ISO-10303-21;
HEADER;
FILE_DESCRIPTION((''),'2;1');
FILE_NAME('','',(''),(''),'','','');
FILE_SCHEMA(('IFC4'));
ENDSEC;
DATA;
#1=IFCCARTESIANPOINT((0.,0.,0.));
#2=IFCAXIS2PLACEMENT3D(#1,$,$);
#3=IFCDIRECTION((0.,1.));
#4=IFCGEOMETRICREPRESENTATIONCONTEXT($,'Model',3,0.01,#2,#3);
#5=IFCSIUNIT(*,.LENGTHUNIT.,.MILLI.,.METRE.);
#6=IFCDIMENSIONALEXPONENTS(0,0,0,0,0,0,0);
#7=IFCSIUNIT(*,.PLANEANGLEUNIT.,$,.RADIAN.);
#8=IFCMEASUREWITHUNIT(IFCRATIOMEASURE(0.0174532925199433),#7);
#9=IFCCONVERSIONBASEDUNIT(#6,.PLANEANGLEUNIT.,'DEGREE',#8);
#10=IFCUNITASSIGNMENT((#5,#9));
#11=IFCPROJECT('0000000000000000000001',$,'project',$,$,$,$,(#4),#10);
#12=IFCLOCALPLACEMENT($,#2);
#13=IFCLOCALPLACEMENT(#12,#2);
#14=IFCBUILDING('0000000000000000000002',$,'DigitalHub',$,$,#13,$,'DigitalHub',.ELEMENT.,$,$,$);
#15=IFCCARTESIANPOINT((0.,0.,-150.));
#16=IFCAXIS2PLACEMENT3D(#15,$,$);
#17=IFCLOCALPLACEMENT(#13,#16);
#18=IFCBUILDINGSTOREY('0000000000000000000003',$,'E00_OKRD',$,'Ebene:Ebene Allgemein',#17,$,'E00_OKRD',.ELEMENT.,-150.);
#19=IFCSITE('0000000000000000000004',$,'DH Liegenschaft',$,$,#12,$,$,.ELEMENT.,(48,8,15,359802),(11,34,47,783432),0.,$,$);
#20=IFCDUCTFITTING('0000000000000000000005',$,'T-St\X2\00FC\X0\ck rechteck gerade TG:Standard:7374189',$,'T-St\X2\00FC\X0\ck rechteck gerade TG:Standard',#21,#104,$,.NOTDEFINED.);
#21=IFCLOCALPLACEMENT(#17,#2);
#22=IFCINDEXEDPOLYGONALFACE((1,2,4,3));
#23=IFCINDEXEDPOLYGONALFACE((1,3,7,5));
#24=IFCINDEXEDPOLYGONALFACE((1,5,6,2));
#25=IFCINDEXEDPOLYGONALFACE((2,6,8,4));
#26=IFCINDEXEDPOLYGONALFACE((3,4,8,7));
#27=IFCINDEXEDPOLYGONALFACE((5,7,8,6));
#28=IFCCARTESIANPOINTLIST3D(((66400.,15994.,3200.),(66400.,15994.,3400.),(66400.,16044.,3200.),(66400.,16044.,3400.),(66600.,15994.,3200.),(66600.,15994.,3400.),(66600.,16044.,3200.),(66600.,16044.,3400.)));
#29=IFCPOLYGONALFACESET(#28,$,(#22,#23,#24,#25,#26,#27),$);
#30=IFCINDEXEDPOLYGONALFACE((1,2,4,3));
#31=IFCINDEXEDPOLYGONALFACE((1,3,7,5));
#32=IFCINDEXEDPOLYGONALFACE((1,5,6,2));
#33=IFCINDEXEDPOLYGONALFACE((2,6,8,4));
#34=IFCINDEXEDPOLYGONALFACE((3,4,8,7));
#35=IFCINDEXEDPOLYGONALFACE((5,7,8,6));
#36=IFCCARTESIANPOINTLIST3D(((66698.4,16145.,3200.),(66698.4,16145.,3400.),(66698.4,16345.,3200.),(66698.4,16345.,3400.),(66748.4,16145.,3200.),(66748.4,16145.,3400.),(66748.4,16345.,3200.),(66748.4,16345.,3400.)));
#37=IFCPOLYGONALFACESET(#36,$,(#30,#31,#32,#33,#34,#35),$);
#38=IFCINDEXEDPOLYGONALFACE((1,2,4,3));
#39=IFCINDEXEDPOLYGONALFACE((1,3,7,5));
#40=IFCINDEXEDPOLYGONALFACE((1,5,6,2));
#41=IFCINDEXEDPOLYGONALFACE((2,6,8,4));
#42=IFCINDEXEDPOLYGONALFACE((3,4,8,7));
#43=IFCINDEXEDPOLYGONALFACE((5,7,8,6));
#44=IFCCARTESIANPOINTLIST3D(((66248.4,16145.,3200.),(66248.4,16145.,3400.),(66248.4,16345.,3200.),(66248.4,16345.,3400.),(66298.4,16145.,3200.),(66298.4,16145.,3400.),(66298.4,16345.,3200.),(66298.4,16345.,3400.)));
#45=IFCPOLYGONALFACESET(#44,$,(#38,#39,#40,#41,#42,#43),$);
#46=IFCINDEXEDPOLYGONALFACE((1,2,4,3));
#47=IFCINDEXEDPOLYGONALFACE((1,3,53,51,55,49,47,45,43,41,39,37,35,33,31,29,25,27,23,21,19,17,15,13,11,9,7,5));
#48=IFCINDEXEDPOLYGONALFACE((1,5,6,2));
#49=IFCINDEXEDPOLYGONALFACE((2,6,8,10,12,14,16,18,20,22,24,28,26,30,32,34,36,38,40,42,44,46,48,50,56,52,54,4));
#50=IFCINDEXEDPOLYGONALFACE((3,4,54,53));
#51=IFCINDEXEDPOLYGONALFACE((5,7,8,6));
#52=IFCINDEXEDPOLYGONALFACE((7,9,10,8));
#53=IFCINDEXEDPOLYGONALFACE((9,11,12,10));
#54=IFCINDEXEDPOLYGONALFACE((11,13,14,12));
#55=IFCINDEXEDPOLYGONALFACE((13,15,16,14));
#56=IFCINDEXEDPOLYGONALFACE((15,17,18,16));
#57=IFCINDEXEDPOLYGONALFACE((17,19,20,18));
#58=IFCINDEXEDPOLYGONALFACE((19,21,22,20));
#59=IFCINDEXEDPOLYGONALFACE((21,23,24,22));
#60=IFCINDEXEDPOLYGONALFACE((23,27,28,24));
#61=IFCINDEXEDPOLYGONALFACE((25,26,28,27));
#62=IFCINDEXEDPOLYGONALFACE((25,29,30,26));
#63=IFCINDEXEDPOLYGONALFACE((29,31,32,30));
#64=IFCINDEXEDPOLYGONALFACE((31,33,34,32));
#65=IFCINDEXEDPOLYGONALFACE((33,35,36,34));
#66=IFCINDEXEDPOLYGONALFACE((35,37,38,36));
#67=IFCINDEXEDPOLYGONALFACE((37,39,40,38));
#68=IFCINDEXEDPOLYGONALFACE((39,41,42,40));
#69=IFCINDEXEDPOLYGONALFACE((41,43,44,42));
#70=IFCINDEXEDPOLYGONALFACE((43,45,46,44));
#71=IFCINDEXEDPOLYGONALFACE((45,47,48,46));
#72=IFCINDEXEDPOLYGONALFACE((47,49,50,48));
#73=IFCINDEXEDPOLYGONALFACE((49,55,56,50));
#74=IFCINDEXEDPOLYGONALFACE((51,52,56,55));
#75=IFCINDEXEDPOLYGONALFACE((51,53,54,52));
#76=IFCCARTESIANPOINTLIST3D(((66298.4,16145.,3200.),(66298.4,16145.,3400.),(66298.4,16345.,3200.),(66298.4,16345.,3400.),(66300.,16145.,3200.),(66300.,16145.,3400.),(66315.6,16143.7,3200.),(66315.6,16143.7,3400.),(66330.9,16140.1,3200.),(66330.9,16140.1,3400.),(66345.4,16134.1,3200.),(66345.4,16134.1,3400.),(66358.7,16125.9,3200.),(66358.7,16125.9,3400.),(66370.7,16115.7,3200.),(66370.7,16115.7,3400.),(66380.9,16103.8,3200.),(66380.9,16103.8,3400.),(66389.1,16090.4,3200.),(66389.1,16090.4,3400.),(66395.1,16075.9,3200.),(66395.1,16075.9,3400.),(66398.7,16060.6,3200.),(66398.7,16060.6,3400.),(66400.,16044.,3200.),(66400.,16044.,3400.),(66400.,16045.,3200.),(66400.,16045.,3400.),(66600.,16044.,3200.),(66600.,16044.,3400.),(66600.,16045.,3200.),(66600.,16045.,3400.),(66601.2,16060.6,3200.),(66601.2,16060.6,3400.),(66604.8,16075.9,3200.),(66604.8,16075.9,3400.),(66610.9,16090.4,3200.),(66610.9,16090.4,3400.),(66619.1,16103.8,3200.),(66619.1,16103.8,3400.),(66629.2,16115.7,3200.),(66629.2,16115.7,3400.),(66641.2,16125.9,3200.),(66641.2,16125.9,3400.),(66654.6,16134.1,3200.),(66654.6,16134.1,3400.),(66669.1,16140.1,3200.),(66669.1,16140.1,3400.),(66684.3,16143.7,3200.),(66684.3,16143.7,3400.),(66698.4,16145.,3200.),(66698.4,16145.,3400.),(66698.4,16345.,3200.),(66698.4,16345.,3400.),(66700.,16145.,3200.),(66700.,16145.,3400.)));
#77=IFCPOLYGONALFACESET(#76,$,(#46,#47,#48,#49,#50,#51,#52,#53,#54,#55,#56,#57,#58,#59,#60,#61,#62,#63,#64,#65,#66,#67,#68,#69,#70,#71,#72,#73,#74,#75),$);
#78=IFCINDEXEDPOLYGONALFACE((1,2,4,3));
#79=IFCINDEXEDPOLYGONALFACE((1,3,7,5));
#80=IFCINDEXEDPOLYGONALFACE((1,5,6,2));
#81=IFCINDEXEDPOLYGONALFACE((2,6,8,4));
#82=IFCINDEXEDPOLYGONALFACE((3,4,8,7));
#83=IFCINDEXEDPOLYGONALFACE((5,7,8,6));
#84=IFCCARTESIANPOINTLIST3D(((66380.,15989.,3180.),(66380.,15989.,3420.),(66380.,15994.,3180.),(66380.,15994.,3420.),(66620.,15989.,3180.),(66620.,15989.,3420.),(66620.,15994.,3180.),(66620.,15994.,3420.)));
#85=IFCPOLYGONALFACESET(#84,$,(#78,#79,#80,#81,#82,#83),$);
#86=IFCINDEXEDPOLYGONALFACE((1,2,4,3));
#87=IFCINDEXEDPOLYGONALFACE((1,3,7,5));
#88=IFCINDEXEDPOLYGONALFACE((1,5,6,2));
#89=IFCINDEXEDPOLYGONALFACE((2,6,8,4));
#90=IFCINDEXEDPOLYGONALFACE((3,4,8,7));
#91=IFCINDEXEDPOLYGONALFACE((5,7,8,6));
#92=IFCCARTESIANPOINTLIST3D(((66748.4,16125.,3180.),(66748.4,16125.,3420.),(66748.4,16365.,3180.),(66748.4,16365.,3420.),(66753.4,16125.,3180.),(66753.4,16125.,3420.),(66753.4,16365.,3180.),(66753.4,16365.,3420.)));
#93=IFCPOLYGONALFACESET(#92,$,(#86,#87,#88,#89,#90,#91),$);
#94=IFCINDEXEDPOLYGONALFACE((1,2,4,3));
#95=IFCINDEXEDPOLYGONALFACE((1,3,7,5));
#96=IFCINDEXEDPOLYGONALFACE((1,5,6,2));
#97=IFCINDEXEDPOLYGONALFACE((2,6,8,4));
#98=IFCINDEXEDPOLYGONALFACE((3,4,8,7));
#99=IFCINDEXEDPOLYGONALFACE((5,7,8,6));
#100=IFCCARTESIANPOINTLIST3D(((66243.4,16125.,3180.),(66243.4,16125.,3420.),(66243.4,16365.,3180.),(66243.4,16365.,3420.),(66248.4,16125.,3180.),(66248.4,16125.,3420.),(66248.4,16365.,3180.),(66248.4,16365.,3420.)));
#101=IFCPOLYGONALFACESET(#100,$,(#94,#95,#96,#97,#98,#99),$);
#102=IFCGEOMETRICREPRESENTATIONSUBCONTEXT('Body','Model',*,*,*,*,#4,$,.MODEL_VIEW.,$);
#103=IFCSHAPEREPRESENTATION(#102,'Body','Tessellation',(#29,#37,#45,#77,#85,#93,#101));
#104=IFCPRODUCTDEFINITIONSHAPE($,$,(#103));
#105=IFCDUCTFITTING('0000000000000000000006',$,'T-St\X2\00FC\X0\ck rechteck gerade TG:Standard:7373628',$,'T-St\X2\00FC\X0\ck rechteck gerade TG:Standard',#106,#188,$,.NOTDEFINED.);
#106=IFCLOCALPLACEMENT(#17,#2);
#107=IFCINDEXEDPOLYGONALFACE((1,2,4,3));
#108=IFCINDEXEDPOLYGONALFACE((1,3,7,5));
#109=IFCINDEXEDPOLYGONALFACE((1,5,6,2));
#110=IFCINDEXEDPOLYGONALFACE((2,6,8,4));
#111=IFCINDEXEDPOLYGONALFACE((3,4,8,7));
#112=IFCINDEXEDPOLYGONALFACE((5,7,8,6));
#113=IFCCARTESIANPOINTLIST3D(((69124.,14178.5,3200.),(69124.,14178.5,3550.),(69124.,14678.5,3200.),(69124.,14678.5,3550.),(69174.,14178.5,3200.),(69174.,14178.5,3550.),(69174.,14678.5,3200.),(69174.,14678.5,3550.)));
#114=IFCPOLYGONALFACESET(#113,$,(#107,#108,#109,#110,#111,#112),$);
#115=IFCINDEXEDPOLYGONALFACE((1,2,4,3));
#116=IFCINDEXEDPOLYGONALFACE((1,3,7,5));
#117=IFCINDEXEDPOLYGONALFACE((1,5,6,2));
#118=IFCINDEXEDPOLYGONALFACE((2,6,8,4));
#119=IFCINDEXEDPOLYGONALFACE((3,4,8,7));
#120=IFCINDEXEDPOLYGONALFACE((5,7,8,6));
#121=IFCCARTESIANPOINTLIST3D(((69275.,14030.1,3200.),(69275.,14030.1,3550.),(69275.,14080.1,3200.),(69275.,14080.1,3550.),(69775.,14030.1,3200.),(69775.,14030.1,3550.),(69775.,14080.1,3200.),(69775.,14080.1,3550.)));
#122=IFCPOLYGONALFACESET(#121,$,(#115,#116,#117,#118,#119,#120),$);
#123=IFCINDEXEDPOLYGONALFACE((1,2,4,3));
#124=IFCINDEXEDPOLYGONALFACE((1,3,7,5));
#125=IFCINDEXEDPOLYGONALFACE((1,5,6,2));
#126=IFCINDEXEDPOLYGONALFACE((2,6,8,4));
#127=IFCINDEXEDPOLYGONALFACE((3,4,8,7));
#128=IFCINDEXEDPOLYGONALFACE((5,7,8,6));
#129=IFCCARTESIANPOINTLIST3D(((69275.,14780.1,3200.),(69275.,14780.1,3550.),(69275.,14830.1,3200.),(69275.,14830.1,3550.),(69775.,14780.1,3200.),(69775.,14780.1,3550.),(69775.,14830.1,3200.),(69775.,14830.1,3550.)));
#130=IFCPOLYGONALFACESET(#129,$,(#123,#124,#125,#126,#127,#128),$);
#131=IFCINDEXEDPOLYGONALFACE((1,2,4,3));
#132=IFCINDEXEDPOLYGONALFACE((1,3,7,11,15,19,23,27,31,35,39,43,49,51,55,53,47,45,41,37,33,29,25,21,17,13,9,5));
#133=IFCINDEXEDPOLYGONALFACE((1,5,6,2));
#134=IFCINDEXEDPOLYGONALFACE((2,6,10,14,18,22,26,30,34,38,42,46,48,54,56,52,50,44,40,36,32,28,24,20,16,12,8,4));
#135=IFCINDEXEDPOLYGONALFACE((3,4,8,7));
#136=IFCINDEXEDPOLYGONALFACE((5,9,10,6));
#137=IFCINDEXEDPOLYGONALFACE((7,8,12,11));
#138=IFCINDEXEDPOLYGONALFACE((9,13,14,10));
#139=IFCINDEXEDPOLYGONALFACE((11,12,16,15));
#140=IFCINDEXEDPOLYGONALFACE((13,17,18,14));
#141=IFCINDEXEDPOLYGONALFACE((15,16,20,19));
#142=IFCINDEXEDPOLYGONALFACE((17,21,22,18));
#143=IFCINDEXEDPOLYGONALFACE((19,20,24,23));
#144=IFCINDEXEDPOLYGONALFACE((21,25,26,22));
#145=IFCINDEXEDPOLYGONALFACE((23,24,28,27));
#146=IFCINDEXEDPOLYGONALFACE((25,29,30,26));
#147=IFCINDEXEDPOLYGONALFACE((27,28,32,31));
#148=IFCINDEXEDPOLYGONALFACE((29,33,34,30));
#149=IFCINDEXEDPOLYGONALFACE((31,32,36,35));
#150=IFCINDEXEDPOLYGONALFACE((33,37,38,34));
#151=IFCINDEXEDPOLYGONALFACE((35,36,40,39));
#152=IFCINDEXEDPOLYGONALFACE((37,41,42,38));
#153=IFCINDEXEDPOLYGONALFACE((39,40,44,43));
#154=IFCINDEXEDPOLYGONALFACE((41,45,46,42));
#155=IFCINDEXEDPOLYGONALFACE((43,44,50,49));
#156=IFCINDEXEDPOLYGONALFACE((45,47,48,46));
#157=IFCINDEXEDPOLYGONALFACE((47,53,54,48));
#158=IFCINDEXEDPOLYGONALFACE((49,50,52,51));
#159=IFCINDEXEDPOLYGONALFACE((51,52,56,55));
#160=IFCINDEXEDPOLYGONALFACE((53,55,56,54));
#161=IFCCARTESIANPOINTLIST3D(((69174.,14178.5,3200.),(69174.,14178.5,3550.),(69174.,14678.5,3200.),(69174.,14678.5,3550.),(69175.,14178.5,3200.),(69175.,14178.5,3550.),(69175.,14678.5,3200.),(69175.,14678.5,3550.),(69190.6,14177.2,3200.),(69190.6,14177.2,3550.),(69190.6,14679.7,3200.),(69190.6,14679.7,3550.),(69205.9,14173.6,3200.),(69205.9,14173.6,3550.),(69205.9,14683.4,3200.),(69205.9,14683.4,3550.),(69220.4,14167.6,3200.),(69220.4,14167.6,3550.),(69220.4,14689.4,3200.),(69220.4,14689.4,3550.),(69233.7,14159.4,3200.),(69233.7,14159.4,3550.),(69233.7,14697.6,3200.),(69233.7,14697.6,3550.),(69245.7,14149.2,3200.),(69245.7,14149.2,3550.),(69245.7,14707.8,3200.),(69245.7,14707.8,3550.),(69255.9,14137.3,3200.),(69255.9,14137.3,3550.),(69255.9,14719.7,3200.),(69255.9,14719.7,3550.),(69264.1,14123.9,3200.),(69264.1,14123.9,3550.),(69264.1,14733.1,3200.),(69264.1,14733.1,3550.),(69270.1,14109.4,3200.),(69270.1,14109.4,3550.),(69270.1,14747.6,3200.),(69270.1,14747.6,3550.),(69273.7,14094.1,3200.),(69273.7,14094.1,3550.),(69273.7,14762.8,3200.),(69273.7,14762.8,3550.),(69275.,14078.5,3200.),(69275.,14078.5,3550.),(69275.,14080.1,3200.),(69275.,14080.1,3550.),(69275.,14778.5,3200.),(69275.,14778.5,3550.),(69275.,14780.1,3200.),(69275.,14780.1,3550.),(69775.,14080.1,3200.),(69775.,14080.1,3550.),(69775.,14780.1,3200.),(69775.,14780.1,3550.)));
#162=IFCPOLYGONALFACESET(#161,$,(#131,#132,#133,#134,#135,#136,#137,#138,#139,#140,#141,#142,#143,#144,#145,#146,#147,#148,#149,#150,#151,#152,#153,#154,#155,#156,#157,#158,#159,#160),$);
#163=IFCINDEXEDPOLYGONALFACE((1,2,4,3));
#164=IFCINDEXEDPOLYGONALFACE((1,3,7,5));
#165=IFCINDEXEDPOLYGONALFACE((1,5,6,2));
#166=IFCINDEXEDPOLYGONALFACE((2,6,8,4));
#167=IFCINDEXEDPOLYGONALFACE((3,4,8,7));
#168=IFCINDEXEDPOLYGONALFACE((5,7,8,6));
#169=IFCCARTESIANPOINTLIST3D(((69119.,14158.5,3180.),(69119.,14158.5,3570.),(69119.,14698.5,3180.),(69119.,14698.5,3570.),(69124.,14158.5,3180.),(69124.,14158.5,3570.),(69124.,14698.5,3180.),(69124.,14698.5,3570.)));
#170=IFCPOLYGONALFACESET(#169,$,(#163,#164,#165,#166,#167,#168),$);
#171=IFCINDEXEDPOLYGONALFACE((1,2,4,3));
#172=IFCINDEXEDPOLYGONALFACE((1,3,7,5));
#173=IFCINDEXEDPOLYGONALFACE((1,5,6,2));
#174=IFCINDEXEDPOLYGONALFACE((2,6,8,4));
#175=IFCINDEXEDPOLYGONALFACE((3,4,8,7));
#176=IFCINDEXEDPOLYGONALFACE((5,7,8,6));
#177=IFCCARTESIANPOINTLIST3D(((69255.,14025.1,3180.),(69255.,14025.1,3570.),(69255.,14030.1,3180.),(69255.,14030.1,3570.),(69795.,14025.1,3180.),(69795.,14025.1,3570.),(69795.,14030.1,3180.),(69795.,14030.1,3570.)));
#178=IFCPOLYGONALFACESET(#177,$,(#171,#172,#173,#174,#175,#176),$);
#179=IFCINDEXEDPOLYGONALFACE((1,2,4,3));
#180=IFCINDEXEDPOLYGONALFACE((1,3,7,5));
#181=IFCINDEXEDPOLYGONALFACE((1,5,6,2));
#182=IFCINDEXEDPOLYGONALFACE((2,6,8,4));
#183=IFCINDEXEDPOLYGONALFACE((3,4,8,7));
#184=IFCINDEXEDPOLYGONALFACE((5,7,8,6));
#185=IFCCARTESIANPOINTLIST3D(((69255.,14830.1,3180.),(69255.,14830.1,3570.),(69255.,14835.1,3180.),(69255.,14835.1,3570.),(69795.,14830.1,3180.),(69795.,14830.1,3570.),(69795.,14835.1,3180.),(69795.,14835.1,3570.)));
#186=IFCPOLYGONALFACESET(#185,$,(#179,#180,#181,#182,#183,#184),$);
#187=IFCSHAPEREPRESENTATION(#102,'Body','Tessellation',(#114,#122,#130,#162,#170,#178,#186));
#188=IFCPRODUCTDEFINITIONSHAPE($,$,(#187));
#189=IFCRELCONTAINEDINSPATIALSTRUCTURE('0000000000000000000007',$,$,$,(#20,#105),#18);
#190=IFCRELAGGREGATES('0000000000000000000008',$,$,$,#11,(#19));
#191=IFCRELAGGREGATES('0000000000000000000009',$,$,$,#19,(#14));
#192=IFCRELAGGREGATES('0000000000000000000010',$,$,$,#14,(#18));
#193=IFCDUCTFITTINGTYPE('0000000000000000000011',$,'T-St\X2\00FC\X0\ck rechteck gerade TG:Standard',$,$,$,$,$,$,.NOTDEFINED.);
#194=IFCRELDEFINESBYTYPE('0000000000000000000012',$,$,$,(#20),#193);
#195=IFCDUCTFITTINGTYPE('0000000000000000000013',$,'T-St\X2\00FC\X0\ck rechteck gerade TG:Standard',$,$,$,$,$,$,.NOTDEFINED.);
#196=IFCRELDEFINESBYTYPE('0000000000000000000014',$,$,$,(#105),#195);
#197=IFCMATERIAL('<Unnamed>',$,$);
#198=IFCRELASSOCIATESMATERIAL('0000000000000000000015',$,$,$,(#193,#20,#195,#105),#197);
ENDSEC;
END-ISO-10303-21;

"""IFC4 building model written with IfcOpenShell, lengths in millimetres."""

from ifc_helpers import new_model, entity, si_unit, converted_unit, direction, frame, origin, place, context, subcontext, project, spatial, indexed_curve, outline, extrude, source, transform, mapped, material, type_object, type_shapes, element, save


model = new_model("IFC4")

# Units and contexts
model_context = context("Model", 3, precision=0.01, world=origin(), true_north=direction((0.0, 1.0)))
body_context = subcontext(model_context, "Body", "Model", "MODEL_VIEW")
ifc_project = project(units=[si_unit("LENGTHUNIT", "METRE", prefix="MILLI"), converted_unit("PLANEANGLEUNIT", "DEGREE", entity("IfcRatioMeasure", 0.0174532925199433), si_unit("PLANEANGLEUNIT", "RADIAN"), dimensions=[0, 0, 0, 0, 0, 0, 0])], contexts=[model_context])

# Site, building, storey
site_placement = place(None, origin())
site = spatial("IfcSite", under=ifc_project, at=site_placement, Name="DH Liegenschaft", CompositionType="ELEMENT", RefLatitude=(48, 8, 15, 359802), RefLongitude=(11, 34, 47, 783432), RefElevation=0.0)
building_placement = place(site_placement, origin())
building = spatial("IfcBuilding", under=site, at=building_placement, Name="DigitalHub", LongName="DigitalHub", CompositionType="ELEMENT")
storey_placement = place(building_placement, frame((0.0, 0.0, -150.0)))
storey = spatial("IfcBuildingStorey", under=building, at=storey_placement, Name="E00_OKRD", ObjectType="Ebene:Ebene Allgemein", LongName="E00_OKRD", CompositionType="ELEMENT", Elevation=-150.0)

# Shared definitions
ifc_material_1 = material(Name="<Unnamed>")

# Duct fittings
duct_fitting_type_1 = type_object("IfcDuctFittingType", Name="T-Stück rechteck gerade TG:Standard", PredefinedType="NOTDEFINED", material=ifc_material_1)
shared_shape_1 = source(origin(), body_context, "Body", "SweptSolid", [
    extrude(outline(indexed_curve([(-25.0, -100.0), (25.0, -100.0), (25.0, 100.0), (-25.0, 100.0), (-25.0, -100.0)], self_intersect=False)), frame((0.0, -226.0, -100.0), z_axis=(0.0, 0.0, 1.0), x_axis=(0.0, -1.0, 0.0)), (0.0, 0.0, 1.0), 200.0),
    extrude(outline(indexed_curve([(-25.0, -100.0), (25.0, -100.0), (25.0, 100.0), (-25.0, 100.0), (-25.0, -100.0)], self_intersect=False)), frame((223.4, 0.0, -100.0), z_axis=(0.0, 0.0, 1.0), x_axis=(-1.0, 0.0, 0.0)), (0.0, 0.0, 1.0), 200.0),
    extrude(outline(indexed_curve([(-25.0, -100.0), (25.0, -100.0), (25.0, 100.0), (-25.0, 100.0), (-25.0, -100.0)], self_intersect=False)), frame((-226.6, 0.0, -100.0)), (0.0, 0.0, 1.0), 200.0),
    extrude(outline(indexed_curve([(-200.6, 0.2), (-185.0, -1.0), (-169.7, -4.7), (-155.2, -10.7), (-141.9, -18.9), (-129.9, -29.1), (-119.7, -41.0), (-111.5, -54.4), (-105.5, -68.9), (-101.9, -84.2), (-100.6, -99.8), (-100.6, -100.8), (99.4, -100.8), (99.4, -99.8), (100.6, -84.2), (104.3, -68.9), (110.3, -54.4), (118.5, -41.0), (128.6, -29.1), (140.6, -18.9), (154.0, -10.7), (168.5, -4.7), (183.7, -1.0), (199.4, 0.2), (201.0, 0.2), (201.0, 200.2), (-199.0, 200.2), (-199.0, 0.2), (-200.6, 0.2)], self_intersect=False)), frame((-0.6, -100.2, -100.0), z_axis=(0.0, 0.0, -1.0), x_axis=(-1.0, 0.0, 0.0)), (0.0, 0.0, -1.0), 200.0),
    extrude(outline(indexed_curve([(-2.5, -120.0), (2.5, -120.0), (2.5, 120.0), (-2.5, 120.0), (-2.5, -120.0)], self_intersect=False)), frame((0.0, -253.5, -120.0), z_axis=(0.0, 0.0, 1.0), x_axis=(0.0, 1.0, 0.0)), (0.0, 0.0, 1.0), 240.0),
    extrude(outline(indexed_curve([(-2.5, -120.0), (2.5, -120.0), (2.5, 120.0), (-2.5, 120.0), (-2.5, -120.0)], self_intersect=False)), frame((250.9, 0.0, -120.0), z_axis=(0.0, 0.0, 1.0), x_axis=(-1.0, 0.0, 0.0)), (0.0, 0.0, 1.0), 240.0),
    extrude(outline(indexed_curve([(-2.5, -120.0), (2.5, -120.0), (2.5, 120.0), (-2.5, 120.0), (-2.5, -120.0)], self_intersect=False)), frame((-254.1, 0.0, -120.0), z_axis=(0.0, 0.0, 1.0), x_axis=(-1.0, 0.0, 0.0)), (0.0, 0.0, 1.0), 240.0),
])
type_shapes(duct_fitting_type_1, [shared_shape_1])
duct_fitting_1_placement = place(storey_placement, frame((66500.0, 16245.0, 3300.0)))
element("IfcDuctFitting", 1, at=duct_fitting_1_placement, inside=storey, type_object=duct_fitting_type_1, material=ifc_material_1, Name="T-Stück rechteck gerade TG:Standard:7374189", ObjectType="T-Stück rechteck gerade TG:Standard", PredefinedType="NOTDEFINED", context=body_context, shape_type="MappedRepresentation", body=[
    mapped(shared_shape_1, transform((0.0, 0.0, 0.0), scale=1.0)),
])
duct_fitting_type_2 = type_object("IfcDuctFittingType", Name="T-Stück rechteck gerade TG:Standard", PredefinedType="NOTDEFINED", material=ifc_material_1)
shared_shape_2 = source(origin(), body_context, "Body", "SweptSolid", [
    extrude(outline(indexed_curve([(-25.0, -250.0), (25.0, -250.0), (25.0, 250.0), (-25.0, 250.0), (-25.0, -250.0)], self_intersect=False)), frame((0.0, -376.0, -175.0), z_axis=(0.0, 0.0, 1.0), x_axis=(0.0, -1.0, 0.0)), (0.0, 0.0, 1.0), 350.0),
    extrude(outline(indexed_curve([(-25.0, -250.0), (25.0, -250.0), (25.0, 250.0), (-25.0, 250.0), (-25.0, -250.0)], self_intersect=False)), frame((373.4, 0.0, -175.0), z_axis=(0.0, 0.0, 1.0), x_axis=(-1.0, 0.0, 0.0)), (0.0, 0.0, 1.0), 350.0),
    extrude(outline(indexed_curve([(-25.0, -250.0), (25.0, -250.0), (25.0, 250.0), (-25.0, 250.0), (-25.0, -250.0)], self_intersect=False)), frame((-376.6, 0.0, -175.0)), (0.0, 0.0, 1.0), 350.0),
    extrude(outline(indexed_curve([(-350.6, -59.8), (-335.0, -61.0), (-319.7, -64.7), (-305.2, -70.7), (-291.9, -78.9), (-279.9, -89.1), (-269.7, -101.0), (-261.5, -114.4), (-255.5, -128.9), (-251.9, -144.2), (-250.6, -159.8), (-250.6, -160.8), (249.4, -160.8), (249.4, -159.8), (250.6, -144.2), (254.3, -128.9), (260.3, -114.4), (268.5, -101.0), (278.6, -89.1), (290.6, -78.9), (304.0, -70.7), (318.5, -64.7), (333.7, -61.0), (349.4, -59.8), (351.0, -59.8), (351.0, 440.2), (-349.0, 440.2), (-349.0, -59.8), (-350.6, -59.8)], self_intersect=False)), frame((-0.6, -190.2, -175.0), z_axis=(0.0, 0.0, -1.0), x_axis=(-1.0, 0.0, 0.0)), (0.0, 0.0, -1.0), 350.0),
    extrude(outline(indexed_curve([(-2.5, -270.0), (2.5, -270.0), (2.5, 270.0), (-2.5, 270.0), (-2.5, -270.0)], self_intersect=False)), frame((0.0, -403.5, -195.0), z_axis=(0.0, 0.0, 1.0), x_axis=(0.0, 1.0, 0.0)), (0.0, 0.0, 1.0), 390.0),
    extrude(outline(indexed_curve([(-2.5, -270.0), (2.5, -270.0), (2.5, 270.0), (-2.5, 270.0), (-2.5, -270.0)], self_intersect=False)), frame((400.9, 0.0, -195.0), z_axis=(0.0, 0.0, 1.0), x_axis=(-1.0, 0.0, 0.0)), (0.0, 0.0, 1.0), 390.0),
    extrude(outline(indexed_curve([(-2.5, -270.0), (2.5, -270.0), (2.5, 270.0), (-2.5, 270.0), (-2.5, -270.0)], self_intersect=False)), frame((-404.1, 0.0, -195.0), z_axis=(0.0, 0.0, 1.0), x_axis=(-1.0, 0.0, 0.0)), (0.0, 0.0, 1.0), 390.0),
])
type_shapes(duct_fitting_type_2, [shared_shape_2])
duct_fitting_2_placement = place(storey_placement, frame((69525.0, 14428.5, 3375.0), z_axis=(0.0, 0.0, 1.0), x_axis=(0.0, -1.0, 0.0)))
element("IfcDuctFitting", 2, at=duct_fitting_2_placement, inside=storey, type_object=duct_fitting_type_2, material=ifc_material_1, Name="T-Stück rechteck gerade TG:Standard:7373628", ObjectType="T-Stück rechteck gerade TG:Standard", PredefinedType="NOTDEFINED", context=body_context, shape_type="MappedRepresentation", body=[
    mapped(shared_shape_2, transform((0.0, 0.0, 0.0), scale=1.0)),
])

save(model, "model.ifc")
